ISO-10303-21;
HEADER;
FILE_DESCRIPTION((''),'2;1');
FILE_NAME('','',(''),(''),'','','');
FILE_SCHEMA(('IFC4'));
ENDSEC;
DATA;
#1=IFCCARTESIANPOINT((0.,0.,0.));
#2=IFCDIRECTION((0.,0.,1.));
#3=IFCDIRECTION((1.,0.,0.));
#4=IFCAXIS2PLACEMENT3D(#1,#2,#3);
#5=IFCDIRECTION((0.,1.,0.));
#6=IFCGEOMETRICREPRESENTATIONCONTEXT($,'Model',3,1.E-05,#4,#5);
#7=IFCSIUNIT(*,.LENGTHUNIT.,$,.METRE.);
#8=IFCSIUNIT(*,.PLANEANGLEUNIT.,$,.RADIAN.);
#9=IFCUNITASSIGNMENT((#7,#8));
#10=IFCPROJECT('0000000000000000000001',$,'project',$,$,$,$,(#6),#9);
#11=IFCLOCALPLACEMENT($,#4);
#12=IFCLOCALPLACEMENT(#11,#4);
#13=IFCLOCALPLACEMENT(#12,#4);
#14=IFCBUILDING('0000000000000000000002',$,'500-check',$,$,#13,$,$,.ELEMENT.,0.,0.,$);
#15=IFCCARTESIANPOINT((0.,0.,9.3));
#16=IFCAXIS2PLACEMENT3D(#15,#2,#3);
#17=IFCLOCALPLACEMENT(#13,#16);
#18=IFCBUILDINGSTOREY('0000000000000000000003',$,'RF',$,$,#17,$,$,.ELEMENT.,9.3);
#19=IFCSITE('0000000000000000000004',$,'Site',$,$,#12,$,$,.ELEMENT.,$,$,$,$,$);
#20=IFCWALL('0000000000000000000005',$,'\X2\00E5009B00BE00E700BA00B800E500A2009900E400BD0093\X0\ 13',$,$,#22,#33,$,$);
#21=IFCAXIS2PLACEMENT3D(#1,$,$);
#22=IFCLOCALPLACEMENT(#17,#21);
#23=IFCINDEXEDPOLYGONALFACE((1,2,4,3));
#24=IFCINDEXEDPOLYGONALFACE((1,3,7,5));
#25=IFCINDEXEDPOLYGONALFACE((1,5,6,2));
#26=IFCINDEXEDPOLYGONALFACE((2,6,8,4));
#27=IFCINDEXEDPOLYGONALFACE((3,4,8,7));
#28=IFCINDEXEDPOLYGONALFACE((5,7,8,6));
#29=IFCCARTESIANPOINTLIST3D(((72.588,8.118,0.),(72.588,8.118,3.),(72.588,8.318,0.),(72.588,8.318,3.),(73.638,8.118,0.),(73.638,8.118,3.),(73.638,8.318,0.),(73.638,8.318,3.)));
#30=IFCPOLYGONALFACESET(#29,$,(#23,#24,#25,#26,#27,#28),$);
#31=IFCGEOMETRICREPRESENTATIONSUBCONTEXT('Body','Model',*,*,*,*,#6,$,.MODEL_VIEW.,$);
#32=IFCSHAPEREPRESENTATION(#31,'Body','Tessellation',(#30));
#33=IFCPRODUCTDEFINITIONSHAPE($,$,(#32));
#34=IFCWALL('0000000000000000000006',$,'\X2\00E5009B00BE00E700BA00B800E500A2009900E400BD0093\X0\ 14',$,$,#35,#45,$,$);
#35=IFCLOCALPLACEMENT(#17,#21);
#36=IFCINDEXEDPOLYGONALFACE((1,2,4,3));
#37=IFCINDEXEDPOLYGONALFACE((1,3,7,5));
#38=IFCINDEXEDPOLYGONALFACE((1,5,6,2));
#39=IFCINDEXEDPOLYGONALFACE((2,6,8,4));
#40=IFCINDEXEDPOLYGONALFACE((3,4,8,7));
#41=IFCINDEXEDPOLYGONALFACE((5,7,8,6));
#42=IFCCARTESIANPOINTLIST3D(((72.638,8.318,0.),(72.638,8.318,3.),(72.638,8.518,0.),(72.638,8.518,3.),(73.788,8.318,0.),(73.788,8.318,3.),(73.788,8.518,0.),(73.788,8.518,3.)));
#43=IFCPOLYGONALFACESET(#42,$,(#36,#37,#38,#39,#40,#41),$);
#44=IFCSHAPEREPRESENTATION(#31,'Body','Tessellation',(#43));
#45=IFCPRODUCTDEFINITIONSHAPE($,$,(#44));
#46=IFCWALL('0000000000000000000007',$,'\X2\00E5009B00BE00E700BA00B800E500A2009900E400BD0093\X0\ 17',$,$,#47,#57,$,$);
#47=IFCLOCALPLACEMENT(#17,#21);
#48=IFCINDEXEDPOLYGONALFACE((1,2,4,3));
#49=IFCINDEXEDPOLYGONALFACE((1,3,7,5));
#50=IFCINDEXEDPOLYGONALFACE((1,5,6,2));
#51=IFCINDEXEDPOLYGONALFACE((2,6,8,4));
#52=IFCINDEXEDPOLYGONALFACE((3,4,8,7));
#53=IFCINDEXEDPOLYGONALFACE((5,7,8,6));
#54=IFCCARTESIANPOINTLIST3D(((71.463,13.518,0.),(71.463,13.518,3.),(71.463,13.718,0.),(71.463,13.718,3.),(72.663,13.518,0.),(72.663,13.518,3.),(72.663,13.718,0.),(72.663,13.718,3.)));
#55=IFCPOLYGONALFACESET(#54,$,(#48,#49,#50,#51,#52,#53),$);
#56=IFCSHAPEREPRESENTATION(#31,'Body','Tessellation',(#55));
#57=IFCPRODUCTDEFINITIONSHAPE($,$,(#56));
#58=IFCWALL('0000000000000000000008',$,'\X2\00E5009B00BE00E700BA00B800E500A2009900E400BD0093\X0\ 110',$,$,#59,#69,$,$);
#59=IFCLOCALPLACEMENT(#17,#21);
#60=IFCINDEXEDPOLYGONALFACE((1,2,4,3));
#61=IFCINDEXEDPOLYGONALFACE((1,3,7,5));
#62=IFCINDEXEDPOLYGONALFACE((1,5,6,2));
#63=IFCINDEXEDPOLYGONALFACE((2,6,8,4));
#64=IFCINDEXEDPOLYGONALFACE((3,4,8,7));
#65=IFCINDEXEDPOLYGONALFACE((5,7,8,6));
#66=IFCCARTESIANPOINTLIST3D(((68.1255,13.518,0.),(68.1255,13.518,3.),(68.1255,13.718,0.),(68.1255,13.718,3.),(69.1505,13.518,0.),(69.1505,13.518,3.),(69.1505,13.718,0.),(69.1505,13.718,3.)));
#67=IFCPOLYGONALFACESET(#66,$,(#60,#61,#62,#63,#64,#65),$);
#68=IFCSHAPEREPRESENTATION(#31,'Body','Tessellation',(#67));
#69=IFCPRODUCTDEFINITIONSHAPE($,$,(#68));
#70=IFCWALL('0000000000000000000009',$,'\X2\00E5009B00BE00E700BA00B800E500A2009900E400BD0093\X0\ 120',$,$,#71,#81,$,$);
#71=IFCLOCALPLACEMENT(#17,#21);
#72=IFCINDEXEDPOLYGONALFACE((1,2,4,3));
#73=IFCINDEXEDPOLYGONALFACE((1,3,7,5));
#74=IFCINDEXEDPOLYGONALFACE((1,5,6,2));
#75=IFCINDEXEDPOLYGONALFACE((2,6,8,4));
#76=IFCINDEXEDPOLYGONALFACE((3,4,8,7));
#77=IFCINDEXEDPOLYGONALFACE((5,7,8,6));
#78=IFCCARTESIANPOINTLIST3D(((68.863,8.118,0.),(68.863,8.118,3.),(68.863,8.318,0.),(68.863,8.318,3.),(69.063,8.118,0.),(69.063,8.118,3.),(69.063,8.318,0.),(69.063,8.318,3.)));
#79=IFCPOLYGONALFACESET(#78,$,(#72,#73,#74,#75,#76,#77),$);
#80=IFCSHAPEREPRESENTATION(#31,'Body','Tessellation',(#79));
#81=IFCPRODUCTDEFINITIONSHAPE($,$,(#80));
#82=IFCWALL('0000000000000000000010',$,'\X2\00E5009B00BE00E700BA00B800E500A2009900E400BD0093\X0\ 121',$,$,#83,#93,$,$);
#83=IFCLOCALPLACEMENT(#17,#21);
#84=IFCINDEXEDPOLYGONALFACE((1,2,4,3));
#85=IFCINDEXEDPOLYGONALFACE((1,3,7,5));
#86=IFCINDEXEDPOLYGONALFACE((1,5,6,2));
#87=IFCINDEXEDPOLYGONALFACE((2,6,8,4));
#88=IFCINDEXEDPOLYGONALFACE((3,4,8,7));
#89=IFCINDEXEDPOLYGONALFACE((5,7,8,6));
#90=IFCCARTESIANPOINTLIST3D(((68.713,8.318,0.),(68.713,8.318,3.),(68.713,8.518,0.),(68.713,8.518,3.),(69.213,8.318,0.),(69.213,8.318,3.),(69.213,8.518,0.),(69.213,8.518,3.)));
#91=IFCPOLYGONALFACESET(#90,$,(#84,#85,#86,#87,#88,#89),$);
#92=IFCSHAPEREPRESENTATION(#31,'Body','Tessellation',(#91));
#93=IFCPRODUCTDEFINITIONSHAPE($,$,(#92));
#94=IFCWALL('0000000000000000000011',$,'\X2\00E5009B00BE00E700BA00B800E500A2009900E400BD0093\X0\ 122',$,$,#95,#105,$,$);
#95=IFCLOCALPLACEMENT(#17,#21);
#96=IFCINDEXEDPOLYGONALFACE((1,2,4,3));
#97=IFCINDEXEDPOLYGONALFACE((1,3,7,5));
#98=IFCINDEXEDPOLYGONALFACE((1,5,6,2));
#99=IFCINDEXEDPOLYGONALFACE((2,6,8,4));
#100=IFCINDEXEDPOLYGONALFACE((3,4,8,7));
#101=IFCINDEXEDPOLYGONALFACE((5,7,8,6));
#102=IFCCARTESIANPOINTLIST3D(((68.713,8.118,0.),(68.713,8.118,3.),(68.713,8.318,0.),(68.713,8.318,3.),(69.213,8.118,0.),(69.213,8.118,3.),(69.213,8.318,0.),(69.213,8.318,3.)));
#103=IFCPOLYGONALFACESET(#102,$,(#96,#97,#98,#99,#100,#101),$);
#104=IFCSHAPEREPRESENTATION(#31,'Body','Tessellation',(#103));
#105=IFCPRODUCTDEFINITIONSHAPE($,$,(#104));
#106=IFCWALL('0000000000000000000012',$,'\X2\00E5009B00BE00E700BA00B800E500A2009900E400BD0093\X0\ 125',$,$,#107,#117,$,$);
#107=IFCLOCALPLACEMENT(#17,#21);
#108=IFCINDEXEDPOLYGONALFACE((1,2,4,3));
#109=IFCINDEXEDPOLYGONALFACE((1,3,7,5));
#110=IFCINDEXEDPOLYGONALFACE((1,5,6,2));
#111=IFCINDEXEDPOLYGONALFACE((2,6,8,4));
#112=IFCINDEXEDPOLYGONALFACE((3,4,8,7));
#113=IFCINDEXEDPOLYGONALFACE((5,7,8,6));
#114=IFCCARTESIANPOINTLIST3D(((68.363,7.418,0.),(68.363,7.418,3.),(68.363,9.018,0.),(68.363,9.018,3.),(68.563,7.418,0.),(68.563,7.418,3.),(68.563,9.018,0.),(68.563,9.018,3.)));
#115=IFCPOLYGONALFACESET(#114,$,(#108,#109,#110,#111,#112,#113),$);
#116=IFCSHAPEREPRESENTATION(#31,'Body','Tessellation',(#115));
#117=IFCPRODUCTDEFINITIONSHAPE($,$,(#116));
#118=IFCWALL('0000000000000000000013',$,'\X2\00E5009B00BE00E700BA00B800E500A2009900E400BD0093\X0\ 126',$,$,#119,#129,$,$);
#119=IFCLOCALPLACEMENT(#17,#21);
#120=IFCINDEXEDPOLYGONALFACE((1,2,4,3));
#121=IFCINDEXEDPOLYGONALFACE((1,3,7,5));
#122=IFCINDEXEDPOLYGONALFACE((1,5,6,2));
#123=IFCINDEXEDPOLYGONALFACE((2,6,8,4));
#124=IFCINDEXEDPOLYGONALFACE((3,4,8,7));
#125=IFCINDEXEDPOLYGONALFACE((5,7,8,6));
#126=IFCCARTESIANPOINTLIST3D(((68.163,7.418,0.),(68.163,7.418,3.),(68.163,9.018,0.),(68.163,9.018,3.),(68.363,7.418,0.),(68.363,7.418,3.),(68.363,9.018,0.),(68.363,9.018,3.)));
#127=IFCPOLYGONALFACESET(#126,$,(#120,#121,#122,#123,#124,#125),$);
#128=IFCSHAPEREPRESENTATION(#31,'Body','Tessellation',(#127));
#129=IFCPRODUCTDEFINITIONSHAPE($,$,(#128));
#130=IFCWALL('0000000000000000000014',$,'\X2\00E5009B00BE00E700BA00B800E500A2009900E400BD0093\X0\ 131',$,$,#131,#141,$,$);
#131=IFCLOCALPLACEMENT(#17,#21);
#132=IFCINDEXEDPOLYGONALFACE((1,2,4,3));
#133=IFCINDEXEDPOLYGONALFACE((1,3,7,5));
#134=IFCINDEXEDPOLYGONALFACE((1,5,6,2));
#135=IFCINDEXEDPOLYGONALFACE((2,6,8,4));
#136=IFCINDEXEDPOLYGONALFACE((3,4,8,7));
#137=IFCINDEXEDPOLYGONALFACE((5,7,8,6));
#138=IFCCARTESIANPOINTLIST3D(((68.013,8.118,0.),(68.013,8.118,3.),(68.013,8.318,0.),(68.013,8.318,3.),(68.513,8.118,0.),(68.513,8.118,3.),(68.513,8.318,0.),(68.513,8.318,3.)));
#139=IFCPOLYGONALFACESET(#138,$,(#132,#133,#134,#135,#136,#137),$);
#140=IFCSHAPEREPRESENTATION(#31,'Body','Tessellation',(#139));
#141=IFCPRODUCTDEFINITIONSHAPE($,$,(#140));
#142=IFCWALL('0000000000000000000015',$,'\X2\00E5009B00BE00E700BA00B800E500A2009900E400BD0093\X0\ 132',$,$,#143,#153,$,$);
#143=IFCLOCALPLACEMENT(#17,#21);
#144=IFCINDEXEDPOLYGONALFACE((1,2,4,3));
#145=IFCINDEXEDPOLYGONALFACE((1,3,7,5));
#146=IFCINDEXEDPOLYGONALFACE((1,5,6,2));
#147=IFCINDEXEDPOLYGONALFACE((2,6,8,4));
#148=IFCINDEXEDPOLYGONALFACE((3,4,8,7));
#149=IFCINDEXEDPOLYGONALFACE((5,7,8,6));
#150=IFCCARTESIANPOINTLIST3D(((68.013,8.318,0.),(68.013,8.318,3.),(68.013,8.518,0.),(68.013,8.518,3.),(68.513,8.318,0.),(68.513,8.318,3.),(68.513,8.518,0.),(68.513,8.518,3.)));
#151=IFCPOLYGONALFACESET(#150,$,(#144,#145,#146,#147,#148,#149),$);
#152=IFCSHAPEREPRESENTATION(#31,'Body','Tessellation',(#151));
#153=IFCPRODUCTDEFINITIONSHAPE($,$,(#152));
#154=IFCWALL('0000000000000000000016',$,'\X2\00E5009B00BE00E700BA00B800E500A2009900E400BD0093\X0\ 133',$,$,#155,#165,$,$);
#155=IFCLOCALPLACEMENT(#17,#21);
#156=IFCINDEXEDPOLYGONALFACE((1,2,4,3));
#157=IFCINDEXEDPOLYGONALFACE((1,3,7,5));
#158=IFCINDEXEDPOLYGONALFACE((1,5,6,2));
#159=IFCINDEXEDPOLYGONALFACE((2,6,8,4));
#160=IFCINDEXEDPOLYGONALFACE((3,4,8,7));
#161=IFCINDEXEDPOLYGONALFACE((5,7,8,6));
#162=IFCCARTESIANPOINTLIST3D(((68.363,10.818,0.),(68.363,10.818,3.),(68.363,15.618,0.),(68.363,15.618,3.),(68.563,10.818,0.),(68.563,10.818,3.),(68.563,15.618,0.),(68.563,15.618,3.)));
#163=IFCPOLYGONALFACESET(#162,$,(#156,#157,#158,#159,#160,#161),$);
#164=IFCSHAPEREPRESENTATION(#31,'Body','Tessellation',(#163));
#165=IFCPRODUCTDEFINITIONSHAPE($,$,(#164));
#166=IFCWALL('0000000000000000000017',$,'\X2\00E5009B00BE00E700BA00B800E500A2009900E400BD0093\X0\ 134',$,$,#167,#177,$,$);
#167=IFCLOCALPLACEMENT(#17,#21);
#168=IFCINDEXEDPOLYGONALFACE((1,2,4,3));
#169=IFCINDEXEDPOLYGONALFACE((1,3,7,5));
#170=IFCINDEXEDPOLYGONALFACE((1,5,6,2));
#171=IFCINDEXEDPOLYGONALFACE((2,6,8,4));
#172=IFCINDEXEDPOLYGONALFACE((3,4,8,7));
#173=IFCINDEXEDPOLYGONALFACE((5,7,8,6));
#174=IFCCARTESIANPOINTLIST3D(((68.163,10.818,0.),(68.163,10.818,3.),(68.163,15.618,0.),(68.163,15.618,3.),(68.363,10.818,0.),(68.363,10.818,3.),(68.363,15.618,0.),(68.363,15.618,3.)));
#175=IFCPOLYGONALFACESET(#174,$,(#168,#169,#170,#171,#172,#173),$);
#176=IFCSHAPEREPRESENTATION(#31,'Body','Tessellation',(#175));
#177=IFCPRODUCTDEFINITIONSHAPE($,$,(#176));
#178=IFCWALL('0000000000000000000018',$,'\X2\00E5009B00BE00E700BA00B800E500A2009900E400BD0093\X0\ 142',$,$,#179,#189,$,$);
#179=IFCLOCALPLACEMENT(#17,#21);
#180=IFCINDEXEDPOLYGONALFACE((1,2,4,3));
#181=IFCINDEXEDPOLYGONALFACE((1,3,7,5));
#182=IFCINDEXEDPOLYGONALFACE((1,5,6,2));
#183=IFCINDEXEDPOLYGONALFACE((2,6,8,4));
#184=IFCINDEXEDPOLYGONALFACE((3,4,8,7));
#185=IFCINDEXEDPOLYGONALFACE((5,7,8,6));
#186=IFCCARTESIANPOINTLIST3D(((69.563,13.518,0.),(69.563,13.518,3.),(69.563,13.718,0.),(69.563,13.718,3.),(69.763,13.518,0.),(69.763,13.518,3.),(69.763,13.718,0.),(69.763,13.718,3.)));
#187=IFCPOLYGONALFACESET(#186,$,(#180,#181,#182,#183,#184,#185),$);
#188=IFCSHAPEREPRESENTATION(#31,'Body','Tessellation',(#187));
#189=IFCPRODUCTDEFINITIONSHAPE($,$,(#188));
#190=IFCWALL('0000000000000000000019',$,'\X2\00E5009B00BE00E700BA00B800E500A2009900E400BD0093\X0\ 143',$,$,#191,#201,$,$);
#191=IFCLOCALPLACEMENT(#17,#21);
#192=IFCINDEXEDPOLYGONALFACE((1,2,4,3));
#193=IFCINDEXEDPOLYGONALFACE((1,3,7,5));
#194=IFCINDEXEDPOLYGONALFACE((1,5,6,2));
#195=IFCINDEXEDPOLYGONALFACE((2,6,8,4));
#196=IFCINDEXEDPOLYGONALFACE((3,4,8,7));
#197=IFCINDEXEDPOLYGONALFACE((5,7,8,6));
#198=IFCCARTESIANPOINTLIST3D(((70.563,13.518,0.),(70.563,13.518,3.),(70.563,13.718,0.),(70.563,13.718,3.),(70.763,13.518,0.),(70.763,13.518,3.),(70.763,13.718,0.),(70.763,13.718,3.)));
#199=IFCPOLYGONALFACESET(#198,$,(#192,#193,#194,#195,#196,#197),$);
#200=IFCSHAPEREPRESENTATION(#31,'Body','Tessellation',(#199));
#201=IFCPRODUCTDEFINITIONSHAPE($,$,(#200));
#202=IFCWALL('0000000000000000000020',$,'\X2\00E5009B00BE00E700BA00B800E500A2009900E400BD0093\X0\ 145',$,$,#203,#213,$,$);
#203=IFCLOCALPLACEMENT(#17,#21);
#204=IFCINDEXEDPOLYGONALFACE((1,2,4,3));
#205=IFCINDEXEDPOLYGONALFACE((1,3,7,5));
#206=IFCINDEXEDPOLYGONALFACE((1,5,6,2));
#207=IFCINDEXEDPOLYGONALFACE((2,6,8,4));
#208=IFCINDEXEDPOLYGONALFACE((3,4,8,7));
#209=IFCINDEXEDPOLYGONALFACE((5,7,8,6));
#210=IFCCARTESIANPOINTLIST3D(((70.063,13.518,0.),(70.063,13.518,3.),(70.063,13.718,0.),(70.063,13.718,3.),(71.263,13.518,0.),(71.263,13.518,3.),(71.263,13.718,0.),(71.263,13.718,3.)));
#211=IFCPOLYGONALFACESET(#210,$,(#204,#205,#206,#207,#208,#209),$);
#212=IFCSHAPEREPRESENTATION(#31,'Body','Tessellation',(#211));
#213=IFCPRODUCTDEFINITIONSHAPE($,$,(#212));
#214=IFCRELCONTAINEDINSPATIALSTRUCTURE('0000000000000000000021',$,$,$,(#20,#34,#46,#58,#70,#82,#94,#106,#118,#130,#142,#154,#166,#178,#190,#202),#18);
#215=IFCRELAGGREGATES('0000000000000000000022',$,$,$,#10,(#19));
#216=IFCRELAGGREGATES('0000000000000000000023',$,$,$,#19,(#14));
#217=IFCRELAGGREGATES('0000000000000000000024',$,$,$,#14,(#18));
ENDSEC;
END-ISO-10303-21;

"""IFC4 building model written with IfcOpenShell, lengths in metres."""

from ifc_helpers import new_model, si_unit, direction, frame, frame_2d, origin_with_axes, place, context, subcontext, project, spatial, rectangle, extrude, element, save


model = new_model("IFC4")

# Units and contexts
model_context = context("Model", 3, precision=1e-05, world=origin_with_axes(), true_north=direction((0.0, 1.0, 0.0)))
body_context = subcontext(model_context, "Body", "Model", "MODEL_VIEW")
ifc_project = project(units=[si_unit("LENGTHUNIT", "METRE"), si_unit("PLANEANGLEUNIT", "RADIAN")], contexts=[model_context])

# Site, building, storey
placement = place(None, origin_with_axes())
site_placement = place(placement, origin_with_axes())
site = spatial("IfcSite", under=ifc_project, at=site_placement, Name="Site", CompositionType="ELEMENT")
building_placement = place(site_placement, origin_with_axes())
building = spatial("IfcBuilding", under=site, at=building_placement, Name="500-check", CompositionType="ELEMENT", ElevationOfRefHeight=0.0, ElevationOfTerrain=0.0)
storey_placement = place(building_placement, frame((0.0, 0.0, 9.3), z_axis=(0.0, 0.0, 1.0), x_axis=(1.0, 0.0, 0.0)))
storey = spatial("IfcBuildingStorey", under=building, at=storey_placement, Name="RF", CompositionType="ELEMENT", Elevation=9.3)

# Walls
wall_1_placement = place(storey_placement, frame((73.113, 8.218, 0.0), z_axis=(0.0, 0.0, 1.0), x_axis=(-1.0, 0.0, 0.0)))
element("IfcWall", 1, at=wall_1_placement, inside=storey, Name="å\u009b¾çº¸å¢\u0099ä½\u0093 13", context=body_context, shape_type="SweptSolid", body=[
    extrude(rectangle(XDim=1.05, YDim=0.2, at=frame_2d((0.0, 0.0), x_axis=(1.0, 0.0, 0.0))), frame((0.0, 0.0, 0.0), z_axis=(0.0, 0.0, 1.0)), (0.0, 0.0, 1.0), 3.0),
])
wall_2_placement = place(storey_placement, frame((73.213, 8.418, 0.0), z_axis=(0.0, 0.0, 1.0), x_axis=(-1.0, 0.0, 0.0)))
element("IfcWall", 2, at=wall_2_placement, inside=storey, Name="å\u009b¾çº¸å¢\u0099ä½\u0093 14", context=body_context, shape_type="SweptSolid", body=[
    extrude(rectangle(XDim=1.15, YDim=0.2, at=frame_2d((0.0, 0.0), x_axis=(1.0, 0.0, 0.0))), frame((0.0, 0.0, 0.0), z_axis=(0.0, 0.0, 1.0)), (0.0, 0.0, 1.0), 3.0),
])
wall_3_placement = place(storey_placement, frame((72.063, 13.618, 0.0), z_axis=(0.0, 0.0, 1.0), x_axis=(1.0, 0.0, 0.0)))
element("IfcWall", 3, at=wall_3_placement, inside=storey, Name="å\u009b¾çº¸å¢\u0099ä½\u0093 17", context=body_context, shape_type="SweptSolid", body=[
    extrude(rectangle(XDim=1.2, YDim=0.2, at=frame_2d((0.0, 0.0), x_axis=(1.0, 0.0, 0.0))), frame((0.0, 0.0, 0.0), z_axis=(0.0, 0.0, 1.0)), (0.0, 0.0, 1.0), 3.0),
])
wall_4_placement = place(storey_placement, frame((68.638, 13.618, 0.0), z_axis=(0.0, 0.0, 1.0), x_axis=(1.0, 0.0, 0.0)))
element("IfcWall", 4, at=wall_4_placement, inside=storey, Name="å\u009b¾çº¸å¢\u0099ä½\u0093 110", context=body_context, shape_type="SweptSolid", body=[
    extrude(rectangle(XDim=1.025, YDim=0.2, at=frame_2d((0.0, 0.0), x_axis=(1.0, 0.0, 0.0))), frame((0.0, 0.0, 0.0), z_axis=(0.0, 0.0, 1.0)), (0.0, 0.0, 1.0), 3.0),
])
wall_5_placement = place(storey_placement, frame((68.963, 8.218, 0.0), z_axis=(0.0, 0.0, 1.0), x_axis=(0.0, 1.0, 0.0)))
element("IfcWall", 5, at=wall_5_placement, inside=storey, Name="å\u009b¾çº¸å¢\u0099ä½\u0093 120", context=body_context, shape_type="SweptSolid", body=[
    extrude(rectangle(XDim=0.2, YDim=0.2, at=frame_2d((0.0, 0.0), x_axis=(1.0, 0.0, 0.0))), frame((0.0, 0.0, 0.0), z_axis=(0.0, 0.0, 1.0)), (0.0, 0.0, 1.0), 3.0),
])
for number, where, z_axis, x_axis, name in (
    (6, (68.963, 8.418, 0.0), (0.0, 0.0, 1.0), (-1.0, 0.0, 0.0), "å\u009b¾çº¸å¢\u0099ä½\u0093 121"),
    (7, (68.963, 8.218, 0.0), (0.0, 0.0, 1.0), (-1.0, 0.0, 0.0), "å\u009b¾çº¸å¢\u0099ä½\u0093 122"),
):
    element("IfcWall", number, at=place(storey_placement, frame(where, z_axis=z_axis, x_axis=x_axis)), inside=storey, Name=name, context=body_context, shape_type="SweptSolid", body=[
        extrude(rectangle(XDim=0.5, YDim=0.2, at=frame_2d((0.0, 0.0), x_axis=(1.0, 0.0, 0.0))), frame((0.0, 0.0, 0.0), z_axis=(0.0, 0.0, 1.0)), (0.0, 0.0, 1.0), 3.0),
    ])
for number, where, z_axis, x_axis, name in (
    (8, (68.463, 8.218, 0.0), (0.0, 0.0, 1.0), (0.0, -1.0, 0.0), "å\u009b¾çº¸å¢\u0099ä½\u0093 125"),
    (9, (68.263, 8.218, 0.0), (0.0, 0.0, 1.0), (0.0, -1.0, 0.0), "å\u009b¾çº¸å¢\u0099ä½\u0093 126"),
):
    element("IfcWall", number, at=place(storey_placement, frame(where, z_axis=z_axis, x_axis=x_axis)), inside=storey, Name=name, context=body_context, shape_type="SweptSolid", body=[
        extrude(rectangle(XDim=1.6, YDim=0.2, at=frame_2d((0.0, 0.0), x_axis=(1.0, 0.0, 0.0))), frame((0.0, 0.0, 0.0), z_axis=(0.0, 0.0, 1.0)), (0.0, 0.0, 1.0), 3.0),
    ])
for number, where, z_axis, x_axis, name in (
    (10, (68.263, 8.218, 0.0), (0.0, 0.0, 1.0), (-1.0, 0.0, 0.0), "å\u009b¾çº¸å¢\u0099ä½\u0093 131"),
    (11, (68.263, 8.418, 0.0), (0.0, 0.0, 1.0), (-1.0, 0.0, 0.0), "å\u009b¾çº¸å¢\u0099ä½\u0093 132"),
):
    element("IfcWall", number, at=place(storey_placement, frame(where, z_axis=z_axis, x_axis=x_axis)), inside=storey, Name=name, context=body_context, shape_type="SweptSolid", body=[
        extrude(rectangle(XDim=0.5, YDim=0.2, at=frame_2d((0.0, 0.0), x_axis=(1.0, 0.0, 0.0))), frame((0.0, 0.0, 0.0), z_axis=(0.0, 0.0, 1.0)), (0.0, 0.0, 1.0), 3.0),
    ])
for number, where, z_axis, x_axis, name in (
    (12, (68.463, 13.218, 0.0), (0.0, 0.0, 1.0), (0.0, -1.0, 0.0), "å\u009b¾çº¸å¢\u0099ä½\u0093 133"),
    (13, (68.263, 13.218, 0.0), (0.0, 0.0, 1.0), (0.0, -1.0, 0.0), "å\u009b¾çº¸å¢\u0099ä½\u0093 134"),
):
    element("IfcWall", number, at=place(storey_placement, frame(where, z_axis=z_axis, x_axis=x_axis)), inside=storey, Name=name, context=body_context, shape_type="SweptSolid", body=[
        extrude(rectangle(XDim=4.8, YDim=0.2, at=frame_2d((0.0, 0.0), x_axis=(1.0, 0.0, 0.0))), frame((0.0, 0.0, 0.0), z_axis=(0.0, 0.0, 1.0)), (0.0, 0.0, 1.0), 3.0),
    ])
for number, where, z_axis, x_axis, name in (
    (14, (69.663, 13.618, 0.0), (0.0, 0.0, 1.0), (0.0, 1.0, 0.0), "å\u009b¾çº¸å¢\u0099ä½\u0093 142"),
    (15, (70.663, 13.618, 0.0), (0.0, 0.0, 1.0), (0.0, 1.0, 0.0), "å\u009b¾çº¸å¢\u0099ä½\u0093 143"),
):
    element("IfcWall", number, at=place(storey_placement, frame(where, z_axis=z_axis, x_axis=x_axis)), inside=storey, Name=name, context=body_context, shape_type="SweptSolid", body=[
        extrude(rectangle(XDim=0.2, YDim=0.2, at=frame_2d((0.0, 0.0), x_axis=(1.0, 0.0, 0.0))), frame((0.0, 0.0, 0.0), z_axis=(0.0, 0.0, 1.0)), (0.0, 0.0, 1.0), 3.0),
    ])
wall_6_placement = place(storey_placement, frame((70.663, 13.618, 0.0), z_axis=(0.0, 0.0, 1.0), x_axis=(1.0, 0.0, 0.0)))
element("IfcWall", 16, at=wall_6_placement, inside=storey, Name="å\u009b¾çº¸å¢\u0099ä½\u0093 145", context=body_context, shape_type="SweptSolid", body=[
    extrude(rectangle(XDim=1.2, YDim=0.2, at=frame_2d((0.0, 0.0), x_axis=(1.0, 0.0, 0.0))), frame((0.0, 0.0, 0.0), z_axis=(0.0, 0.0, 1.0)), (0.0, 0.0, 1.0), 3.0),
])

save(model, "model.ifc")
